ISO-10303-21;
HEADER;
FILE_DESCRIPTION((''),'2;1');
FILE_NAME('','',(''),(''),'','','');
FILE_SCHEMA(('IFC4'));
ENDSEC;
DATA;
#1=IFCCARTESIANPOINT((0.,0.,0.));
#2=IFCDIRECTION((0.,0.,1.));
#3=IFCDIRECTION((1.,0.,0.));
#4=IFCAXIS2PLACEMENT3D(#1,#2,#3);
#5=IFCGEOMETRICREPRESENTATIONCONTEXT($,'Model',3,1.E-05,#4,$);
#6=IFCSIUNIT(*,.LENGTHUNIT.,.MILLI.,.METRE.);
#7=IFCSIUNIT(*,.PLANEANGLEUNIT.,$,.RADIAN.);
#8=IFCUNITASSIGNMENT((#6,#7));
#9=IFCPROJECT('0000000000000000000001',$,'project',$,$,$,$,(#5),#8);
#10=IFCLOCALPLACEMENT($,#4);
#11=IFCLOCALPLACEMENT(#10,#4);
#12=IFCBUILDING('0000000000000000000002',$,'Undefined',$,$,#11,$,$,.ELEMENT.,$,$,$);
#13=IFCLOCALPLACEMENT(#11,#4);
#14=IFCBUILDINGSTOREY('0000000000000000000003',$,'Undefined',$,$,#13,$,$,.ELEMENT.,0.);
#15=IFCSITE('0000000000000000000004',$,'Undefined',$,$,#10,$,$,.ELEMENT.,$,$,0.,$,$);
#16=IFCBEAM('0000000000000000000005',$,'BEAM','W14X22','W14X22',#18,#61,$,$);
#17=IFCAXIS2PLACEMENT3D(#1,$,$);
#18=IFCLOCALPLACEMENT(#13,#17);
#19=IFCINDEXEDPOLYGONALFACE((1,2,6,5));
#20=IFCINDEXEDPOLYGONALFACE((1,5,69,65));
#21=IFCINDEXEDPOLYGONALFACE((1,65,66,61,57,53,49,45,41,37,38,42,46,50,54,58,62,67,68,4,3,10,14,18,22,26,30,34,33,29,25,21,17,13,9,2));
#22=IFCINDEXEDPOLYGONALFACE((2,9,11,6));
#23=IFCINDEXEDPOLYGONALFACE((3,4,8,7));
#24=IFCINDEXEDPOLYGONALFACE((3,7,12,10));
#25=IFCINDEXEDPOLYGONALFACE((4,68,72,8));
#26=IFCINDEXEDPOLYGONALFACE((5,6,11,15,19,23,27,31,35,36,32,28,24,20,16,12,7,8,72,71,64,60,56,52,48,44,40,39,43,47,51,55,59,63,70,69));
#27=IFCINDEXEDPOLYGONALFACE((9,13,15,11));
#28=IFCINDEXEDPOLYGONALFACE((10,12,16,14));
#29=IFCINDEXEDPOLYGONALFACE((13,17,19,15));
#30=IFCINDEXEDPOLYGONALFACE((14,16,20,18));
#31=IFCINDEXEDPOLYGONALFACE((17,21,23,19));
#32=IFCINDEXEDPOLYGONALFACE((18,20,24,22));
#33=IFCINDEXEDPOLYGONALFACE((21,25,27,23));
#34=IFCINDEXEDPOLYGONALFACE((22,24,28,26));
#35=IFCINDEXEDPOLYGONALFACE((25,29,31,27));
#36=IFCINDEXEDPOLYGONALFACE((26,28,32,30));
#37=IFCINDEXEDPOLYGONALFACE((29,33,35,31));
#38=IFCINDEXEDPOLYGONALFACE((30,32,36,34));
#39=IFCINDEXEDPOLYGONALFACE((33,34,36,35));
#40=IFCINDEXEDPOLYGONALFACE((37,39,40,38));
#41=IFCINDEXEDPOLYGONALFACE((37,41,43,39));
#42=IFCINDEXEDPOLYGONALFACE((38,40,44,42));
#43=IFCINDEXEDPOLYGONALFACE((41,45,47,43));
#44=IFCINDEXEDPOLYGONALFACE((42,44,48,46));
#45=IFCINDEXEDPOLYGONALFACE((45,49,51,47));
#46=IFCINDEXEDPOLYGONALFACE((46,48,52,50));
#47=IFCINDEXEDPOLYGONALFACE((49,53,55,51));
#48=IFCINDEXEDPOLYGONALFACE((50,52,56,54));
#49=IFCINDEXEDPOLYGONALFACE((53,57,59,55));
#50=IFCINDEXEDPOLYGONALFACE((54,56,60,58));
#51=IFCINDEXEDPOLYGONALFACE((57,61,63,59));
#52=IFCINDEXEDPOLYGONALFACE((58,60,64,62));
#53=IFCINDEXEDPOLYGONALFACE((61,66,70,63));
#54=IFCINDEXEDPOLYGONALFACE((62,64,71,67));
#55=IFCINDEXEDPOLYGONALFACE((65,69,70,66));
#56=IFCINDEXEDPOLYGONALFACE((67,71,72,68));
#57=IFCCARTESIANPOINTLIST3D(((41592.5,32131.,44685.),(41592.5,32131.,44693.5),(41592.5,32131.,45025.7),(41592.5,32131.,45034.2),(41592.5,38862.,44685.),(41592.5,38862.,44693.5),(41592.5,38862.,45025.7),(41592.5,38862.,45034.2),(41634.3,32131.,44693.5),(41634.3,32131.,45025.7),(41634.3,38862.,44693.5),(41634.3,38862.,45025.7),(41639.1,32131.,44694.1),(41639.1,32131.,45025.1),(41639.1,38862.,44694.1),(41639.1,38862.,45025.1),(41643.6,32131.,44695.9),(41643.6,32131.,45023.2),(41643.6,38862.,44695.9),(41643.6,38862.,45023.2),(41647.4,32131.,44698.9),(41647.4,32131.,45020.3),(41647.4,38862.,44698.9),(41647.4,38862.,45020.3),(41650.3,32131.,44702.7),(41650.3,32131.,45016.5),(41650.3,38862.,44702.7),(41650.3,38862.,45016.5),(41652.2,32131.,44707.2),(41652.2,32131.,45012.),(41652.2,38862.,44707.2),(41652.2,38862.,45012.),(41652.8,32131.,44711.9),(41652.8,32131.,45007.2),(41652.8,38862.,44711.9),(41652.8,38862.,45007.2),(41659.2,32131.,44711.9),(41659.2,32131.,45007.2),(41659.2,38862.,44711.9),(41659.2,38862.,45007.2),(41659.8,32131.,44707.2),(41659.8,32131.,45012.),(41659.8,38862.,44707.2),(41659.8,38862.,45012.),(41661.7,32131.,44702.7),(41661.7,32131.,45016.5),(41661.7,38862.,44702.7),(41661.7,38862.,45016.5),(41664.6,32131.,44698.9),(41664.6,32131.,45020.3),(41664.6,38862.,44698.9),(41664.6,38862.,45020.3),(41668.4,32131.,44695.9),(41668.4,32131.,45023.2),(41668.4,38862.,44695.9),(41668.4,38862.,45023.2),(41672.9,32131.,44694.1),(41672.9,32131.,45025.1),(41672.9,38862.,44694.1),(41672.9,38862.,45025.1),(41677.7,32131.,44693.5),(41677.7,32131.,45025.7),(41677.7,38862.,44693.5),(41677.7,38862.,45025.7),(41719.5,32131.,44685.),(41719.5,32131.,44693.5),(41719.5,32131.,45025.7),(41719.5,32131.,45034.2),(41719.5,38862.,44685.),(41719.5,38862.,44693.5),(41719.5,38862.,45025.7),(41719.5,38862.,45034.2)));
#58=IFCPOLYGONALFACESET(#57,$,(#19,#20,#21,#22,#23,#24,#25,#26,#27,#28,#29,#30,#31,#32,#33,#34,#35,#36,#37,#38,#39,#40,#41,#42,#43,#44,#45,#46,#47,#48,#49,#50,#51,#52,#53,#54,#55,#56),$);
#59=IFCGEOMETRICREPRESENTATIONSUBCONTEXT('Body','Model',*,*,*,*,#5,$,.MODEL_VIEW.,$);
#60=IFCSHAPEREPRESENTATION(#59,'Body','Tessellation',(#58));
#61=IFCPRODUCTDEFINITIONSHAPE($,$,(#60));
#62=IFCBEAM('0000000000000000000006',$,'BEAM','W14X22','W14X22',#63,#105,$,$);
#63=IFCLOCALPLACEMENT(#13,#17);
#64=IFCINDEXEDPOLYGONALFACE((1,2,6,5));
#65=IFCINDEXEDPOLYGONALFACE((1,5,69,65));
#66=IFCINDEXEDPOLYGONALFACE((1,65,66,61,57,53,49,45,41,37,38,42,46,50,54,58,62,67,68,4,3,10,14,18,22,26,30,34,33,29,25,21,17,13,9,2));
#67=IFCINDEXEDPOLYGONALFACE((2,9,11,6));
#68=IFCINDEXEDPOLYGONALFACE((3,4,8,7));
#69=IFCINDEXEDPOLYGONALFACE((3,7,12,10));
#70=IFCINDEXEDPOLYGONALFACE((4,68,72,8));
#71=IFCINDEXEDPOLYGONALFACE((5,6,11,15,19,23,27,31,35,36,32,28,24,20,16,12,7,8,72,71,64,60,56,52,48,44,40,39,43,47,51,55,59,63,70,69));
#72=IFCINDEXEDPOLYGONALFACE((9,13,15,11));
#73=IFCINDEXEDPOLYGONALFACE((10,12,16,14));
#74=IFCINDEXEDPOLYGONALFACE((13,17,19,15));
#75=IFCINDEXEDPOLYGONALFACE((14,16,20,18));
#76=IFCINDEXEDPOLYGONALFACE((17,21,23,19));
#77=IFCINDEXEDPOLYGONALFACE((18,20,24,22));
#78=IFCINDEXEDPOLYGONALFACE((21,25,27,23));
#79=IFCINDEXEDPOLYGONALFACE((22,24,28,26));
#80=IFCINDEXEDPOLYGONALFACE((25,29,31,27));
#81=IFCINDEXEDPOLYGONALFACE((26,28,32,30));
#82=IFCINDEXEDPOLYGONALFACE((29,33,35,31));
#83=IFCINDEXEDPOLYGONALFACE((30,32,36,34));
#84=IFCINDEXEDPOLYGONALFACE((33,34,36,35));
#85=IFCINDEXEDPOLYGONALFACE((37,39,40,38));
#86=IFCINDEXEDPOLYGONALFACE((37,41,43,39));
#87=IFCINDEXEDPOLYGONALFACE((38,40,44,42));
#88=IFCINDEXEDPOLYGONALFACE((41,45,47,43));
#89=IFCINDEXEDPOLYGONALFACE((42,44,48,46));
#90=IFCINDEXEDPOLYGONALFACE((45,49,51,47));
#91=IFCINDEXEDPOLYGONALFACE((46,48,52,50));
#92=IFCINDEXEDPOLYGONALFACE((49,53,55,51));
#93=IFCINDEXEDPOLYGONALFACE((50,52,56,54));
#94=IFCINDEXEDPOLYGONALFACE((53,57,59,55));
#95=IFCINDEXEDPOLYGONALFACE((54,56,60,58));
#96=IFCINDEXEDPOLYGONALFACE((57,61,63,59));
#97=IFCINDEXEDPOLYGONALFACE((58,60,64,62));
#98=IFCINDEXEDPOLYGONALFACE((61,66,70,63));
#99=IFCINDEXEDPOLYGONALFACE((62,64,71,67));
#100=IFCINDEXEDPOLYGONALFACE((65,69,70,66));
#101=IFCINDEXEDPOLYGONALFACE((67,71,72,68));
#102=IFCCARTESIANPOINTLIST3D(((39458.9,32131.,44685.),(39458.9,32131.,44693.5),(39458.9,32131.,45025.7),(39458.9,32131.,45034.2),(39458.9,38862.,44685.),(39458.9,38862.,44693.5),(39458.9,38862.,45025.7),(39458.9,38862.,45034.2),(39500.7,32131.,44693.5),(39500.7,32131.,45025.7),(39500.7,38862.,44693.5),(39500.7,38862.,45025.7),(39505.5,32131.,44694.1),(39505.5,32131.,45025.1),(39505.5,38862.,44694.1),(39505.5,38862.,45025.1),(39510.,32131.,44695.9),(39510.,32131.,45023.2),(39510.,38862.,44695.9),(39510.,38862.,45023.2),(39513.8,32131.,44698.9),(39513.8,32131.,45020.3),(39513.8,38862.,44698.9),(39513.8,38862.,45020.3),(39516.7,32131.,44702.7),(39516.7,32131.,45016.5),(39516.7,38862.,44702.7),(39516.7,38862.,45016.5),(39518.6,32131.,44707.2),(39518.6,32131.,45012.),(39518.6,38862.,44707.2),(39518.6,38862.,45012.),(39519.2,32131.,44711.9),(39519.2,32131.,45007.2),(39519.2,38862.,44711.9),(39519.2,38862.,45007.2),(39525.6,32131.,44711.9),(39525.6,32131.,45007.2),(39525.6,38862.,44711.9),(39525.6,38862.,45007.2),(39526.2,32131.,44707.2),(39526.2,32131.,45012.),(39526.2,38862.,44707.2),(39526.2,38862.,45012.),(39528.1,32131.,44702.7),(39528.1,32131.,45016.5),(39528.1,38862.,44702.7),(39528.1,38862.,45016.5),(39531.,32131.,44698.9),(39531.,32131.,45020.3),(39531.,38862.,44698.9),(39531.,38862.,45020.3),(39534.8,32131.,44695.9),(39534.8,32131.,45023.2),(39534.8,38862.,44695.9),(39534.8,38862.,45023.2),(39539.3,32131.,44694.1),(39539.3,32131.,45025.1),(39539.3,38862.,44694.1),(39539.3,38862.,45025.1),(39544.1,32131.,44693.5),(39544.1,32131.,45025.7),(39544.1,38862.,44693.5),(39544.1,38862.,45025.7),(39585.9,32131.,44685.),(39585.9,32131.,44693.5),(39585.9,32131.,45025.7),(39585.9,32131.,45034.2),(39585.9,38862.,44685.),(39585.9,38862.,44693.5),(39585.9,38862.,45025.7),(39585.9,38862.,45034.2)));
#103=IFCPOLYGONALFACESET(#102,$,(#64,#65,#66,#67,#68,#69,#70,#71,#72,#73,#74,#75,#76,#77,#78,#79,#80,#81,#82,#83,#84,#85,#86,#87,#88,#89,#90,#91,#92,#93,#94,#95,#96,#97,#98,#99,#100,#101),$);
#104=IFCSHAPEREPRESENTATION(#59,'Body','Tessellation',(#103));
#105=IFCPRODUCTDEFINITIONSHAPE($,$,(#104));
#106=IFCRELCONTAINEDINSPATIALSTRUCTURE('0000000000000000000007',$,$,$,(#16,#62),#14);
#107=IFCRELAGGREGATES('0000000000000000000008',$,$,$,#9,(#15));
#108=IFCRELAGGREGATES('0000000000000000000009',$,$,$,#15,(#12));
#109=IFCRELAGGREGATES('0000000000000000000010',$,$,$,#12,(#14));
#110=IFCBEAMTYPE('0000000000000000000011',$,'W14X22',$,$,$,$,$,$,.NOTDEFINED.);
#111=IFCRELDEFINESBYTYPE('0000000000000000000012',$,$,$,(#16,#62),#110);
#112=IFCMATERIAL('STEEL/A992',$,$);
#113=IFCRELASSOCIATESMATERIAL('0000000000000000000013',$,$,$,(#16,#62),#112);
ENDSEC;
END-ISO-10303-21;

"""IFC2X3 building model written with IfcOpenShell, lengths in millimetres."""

from ifc_helpers import new_model, si_unit, frame, origin_with_axes, origin_2d_with_axis, place, context, subcontext, project, spatial, i_section, extrude, material, type_object, element, save


model = new_model("IFC2X3")

# Units and contexts
model_context = context("Model", 3, precision=1e-05, world=origin_with_axes())
body_context = subcontext(model_context, "Body", "Model", "MODEL_VIEW")
ifc_project = project(units=[si_unit("LENGTHUNIT", "METRE", prefix="MILLI"), si_unit("PLANEANGLEUNIT", "RADIAN")], contexts=[model_context])

# Site, building, storey
site_placement = place(None, origin_with_axes())
site = spatial("IfcSite", under=ifc_project, at=site_placement, Name="Undefined", CompositionType="ELEMENT", RefElevation=0.0)
building_placement = place(site_placement, origin_with_axes())
building = spatial("IfcBuilding", under=site, at=building_placement, Name="Undefined", CompositionType="ELEMENT")
storey_placement = place(building_placement, origin_with_axes())
storey = spatial("IfcBuildingStorey", under=building, at=storey_placement, Name="Undefined", CompositionType="ELEMENT", Elevation=0.0)

# Shared definitions
ifc_material = material(Name="STEEL/A992")

# Beams
beam_type_1 = type_object("IfcBeamType", Name="W14X22", PredefinedType="NOTDEFINED")
for number, where, z_axis, x_axis, name in (
    (1, (41656.0, 32131.0, 44859.6), (0.0, 0.0, 1.0), (0.0, 1.0, 0.0), "BEAM"),
    (2, (39522.4, 32131.0, 44859.6), (0.0, 0.0, 1.0), (0.0, 1.0, 0.0), "BEAM"),
):
    element("IfcBeam", number, at=place(storey_placement, frame(where, z_axis=z_axis, x_axis=x_axis)), inside=storey, type_object=beam_type_1, material=ifc_material, Name=name, Description="W14X22", ObjectType="W14X22", context=body_context, shape_type="SweptSolid", body=[
        extrude(i_section(OverallWidth=127.0, OverallDepth=349.2, WebThickness=6.3, FlangeThickness=8.5, FilletRadius=18.5, at=origin_2d_with_axis()), frame((6731.0, 0.0, 0.0), z_axis=(-1.0, 0.0, 0.0), x_axis=(0.0, -1.0, 0.0)), (0.0, 0.0, 1.0), 6731.0),
    ])

save(model, "model.ifc")
